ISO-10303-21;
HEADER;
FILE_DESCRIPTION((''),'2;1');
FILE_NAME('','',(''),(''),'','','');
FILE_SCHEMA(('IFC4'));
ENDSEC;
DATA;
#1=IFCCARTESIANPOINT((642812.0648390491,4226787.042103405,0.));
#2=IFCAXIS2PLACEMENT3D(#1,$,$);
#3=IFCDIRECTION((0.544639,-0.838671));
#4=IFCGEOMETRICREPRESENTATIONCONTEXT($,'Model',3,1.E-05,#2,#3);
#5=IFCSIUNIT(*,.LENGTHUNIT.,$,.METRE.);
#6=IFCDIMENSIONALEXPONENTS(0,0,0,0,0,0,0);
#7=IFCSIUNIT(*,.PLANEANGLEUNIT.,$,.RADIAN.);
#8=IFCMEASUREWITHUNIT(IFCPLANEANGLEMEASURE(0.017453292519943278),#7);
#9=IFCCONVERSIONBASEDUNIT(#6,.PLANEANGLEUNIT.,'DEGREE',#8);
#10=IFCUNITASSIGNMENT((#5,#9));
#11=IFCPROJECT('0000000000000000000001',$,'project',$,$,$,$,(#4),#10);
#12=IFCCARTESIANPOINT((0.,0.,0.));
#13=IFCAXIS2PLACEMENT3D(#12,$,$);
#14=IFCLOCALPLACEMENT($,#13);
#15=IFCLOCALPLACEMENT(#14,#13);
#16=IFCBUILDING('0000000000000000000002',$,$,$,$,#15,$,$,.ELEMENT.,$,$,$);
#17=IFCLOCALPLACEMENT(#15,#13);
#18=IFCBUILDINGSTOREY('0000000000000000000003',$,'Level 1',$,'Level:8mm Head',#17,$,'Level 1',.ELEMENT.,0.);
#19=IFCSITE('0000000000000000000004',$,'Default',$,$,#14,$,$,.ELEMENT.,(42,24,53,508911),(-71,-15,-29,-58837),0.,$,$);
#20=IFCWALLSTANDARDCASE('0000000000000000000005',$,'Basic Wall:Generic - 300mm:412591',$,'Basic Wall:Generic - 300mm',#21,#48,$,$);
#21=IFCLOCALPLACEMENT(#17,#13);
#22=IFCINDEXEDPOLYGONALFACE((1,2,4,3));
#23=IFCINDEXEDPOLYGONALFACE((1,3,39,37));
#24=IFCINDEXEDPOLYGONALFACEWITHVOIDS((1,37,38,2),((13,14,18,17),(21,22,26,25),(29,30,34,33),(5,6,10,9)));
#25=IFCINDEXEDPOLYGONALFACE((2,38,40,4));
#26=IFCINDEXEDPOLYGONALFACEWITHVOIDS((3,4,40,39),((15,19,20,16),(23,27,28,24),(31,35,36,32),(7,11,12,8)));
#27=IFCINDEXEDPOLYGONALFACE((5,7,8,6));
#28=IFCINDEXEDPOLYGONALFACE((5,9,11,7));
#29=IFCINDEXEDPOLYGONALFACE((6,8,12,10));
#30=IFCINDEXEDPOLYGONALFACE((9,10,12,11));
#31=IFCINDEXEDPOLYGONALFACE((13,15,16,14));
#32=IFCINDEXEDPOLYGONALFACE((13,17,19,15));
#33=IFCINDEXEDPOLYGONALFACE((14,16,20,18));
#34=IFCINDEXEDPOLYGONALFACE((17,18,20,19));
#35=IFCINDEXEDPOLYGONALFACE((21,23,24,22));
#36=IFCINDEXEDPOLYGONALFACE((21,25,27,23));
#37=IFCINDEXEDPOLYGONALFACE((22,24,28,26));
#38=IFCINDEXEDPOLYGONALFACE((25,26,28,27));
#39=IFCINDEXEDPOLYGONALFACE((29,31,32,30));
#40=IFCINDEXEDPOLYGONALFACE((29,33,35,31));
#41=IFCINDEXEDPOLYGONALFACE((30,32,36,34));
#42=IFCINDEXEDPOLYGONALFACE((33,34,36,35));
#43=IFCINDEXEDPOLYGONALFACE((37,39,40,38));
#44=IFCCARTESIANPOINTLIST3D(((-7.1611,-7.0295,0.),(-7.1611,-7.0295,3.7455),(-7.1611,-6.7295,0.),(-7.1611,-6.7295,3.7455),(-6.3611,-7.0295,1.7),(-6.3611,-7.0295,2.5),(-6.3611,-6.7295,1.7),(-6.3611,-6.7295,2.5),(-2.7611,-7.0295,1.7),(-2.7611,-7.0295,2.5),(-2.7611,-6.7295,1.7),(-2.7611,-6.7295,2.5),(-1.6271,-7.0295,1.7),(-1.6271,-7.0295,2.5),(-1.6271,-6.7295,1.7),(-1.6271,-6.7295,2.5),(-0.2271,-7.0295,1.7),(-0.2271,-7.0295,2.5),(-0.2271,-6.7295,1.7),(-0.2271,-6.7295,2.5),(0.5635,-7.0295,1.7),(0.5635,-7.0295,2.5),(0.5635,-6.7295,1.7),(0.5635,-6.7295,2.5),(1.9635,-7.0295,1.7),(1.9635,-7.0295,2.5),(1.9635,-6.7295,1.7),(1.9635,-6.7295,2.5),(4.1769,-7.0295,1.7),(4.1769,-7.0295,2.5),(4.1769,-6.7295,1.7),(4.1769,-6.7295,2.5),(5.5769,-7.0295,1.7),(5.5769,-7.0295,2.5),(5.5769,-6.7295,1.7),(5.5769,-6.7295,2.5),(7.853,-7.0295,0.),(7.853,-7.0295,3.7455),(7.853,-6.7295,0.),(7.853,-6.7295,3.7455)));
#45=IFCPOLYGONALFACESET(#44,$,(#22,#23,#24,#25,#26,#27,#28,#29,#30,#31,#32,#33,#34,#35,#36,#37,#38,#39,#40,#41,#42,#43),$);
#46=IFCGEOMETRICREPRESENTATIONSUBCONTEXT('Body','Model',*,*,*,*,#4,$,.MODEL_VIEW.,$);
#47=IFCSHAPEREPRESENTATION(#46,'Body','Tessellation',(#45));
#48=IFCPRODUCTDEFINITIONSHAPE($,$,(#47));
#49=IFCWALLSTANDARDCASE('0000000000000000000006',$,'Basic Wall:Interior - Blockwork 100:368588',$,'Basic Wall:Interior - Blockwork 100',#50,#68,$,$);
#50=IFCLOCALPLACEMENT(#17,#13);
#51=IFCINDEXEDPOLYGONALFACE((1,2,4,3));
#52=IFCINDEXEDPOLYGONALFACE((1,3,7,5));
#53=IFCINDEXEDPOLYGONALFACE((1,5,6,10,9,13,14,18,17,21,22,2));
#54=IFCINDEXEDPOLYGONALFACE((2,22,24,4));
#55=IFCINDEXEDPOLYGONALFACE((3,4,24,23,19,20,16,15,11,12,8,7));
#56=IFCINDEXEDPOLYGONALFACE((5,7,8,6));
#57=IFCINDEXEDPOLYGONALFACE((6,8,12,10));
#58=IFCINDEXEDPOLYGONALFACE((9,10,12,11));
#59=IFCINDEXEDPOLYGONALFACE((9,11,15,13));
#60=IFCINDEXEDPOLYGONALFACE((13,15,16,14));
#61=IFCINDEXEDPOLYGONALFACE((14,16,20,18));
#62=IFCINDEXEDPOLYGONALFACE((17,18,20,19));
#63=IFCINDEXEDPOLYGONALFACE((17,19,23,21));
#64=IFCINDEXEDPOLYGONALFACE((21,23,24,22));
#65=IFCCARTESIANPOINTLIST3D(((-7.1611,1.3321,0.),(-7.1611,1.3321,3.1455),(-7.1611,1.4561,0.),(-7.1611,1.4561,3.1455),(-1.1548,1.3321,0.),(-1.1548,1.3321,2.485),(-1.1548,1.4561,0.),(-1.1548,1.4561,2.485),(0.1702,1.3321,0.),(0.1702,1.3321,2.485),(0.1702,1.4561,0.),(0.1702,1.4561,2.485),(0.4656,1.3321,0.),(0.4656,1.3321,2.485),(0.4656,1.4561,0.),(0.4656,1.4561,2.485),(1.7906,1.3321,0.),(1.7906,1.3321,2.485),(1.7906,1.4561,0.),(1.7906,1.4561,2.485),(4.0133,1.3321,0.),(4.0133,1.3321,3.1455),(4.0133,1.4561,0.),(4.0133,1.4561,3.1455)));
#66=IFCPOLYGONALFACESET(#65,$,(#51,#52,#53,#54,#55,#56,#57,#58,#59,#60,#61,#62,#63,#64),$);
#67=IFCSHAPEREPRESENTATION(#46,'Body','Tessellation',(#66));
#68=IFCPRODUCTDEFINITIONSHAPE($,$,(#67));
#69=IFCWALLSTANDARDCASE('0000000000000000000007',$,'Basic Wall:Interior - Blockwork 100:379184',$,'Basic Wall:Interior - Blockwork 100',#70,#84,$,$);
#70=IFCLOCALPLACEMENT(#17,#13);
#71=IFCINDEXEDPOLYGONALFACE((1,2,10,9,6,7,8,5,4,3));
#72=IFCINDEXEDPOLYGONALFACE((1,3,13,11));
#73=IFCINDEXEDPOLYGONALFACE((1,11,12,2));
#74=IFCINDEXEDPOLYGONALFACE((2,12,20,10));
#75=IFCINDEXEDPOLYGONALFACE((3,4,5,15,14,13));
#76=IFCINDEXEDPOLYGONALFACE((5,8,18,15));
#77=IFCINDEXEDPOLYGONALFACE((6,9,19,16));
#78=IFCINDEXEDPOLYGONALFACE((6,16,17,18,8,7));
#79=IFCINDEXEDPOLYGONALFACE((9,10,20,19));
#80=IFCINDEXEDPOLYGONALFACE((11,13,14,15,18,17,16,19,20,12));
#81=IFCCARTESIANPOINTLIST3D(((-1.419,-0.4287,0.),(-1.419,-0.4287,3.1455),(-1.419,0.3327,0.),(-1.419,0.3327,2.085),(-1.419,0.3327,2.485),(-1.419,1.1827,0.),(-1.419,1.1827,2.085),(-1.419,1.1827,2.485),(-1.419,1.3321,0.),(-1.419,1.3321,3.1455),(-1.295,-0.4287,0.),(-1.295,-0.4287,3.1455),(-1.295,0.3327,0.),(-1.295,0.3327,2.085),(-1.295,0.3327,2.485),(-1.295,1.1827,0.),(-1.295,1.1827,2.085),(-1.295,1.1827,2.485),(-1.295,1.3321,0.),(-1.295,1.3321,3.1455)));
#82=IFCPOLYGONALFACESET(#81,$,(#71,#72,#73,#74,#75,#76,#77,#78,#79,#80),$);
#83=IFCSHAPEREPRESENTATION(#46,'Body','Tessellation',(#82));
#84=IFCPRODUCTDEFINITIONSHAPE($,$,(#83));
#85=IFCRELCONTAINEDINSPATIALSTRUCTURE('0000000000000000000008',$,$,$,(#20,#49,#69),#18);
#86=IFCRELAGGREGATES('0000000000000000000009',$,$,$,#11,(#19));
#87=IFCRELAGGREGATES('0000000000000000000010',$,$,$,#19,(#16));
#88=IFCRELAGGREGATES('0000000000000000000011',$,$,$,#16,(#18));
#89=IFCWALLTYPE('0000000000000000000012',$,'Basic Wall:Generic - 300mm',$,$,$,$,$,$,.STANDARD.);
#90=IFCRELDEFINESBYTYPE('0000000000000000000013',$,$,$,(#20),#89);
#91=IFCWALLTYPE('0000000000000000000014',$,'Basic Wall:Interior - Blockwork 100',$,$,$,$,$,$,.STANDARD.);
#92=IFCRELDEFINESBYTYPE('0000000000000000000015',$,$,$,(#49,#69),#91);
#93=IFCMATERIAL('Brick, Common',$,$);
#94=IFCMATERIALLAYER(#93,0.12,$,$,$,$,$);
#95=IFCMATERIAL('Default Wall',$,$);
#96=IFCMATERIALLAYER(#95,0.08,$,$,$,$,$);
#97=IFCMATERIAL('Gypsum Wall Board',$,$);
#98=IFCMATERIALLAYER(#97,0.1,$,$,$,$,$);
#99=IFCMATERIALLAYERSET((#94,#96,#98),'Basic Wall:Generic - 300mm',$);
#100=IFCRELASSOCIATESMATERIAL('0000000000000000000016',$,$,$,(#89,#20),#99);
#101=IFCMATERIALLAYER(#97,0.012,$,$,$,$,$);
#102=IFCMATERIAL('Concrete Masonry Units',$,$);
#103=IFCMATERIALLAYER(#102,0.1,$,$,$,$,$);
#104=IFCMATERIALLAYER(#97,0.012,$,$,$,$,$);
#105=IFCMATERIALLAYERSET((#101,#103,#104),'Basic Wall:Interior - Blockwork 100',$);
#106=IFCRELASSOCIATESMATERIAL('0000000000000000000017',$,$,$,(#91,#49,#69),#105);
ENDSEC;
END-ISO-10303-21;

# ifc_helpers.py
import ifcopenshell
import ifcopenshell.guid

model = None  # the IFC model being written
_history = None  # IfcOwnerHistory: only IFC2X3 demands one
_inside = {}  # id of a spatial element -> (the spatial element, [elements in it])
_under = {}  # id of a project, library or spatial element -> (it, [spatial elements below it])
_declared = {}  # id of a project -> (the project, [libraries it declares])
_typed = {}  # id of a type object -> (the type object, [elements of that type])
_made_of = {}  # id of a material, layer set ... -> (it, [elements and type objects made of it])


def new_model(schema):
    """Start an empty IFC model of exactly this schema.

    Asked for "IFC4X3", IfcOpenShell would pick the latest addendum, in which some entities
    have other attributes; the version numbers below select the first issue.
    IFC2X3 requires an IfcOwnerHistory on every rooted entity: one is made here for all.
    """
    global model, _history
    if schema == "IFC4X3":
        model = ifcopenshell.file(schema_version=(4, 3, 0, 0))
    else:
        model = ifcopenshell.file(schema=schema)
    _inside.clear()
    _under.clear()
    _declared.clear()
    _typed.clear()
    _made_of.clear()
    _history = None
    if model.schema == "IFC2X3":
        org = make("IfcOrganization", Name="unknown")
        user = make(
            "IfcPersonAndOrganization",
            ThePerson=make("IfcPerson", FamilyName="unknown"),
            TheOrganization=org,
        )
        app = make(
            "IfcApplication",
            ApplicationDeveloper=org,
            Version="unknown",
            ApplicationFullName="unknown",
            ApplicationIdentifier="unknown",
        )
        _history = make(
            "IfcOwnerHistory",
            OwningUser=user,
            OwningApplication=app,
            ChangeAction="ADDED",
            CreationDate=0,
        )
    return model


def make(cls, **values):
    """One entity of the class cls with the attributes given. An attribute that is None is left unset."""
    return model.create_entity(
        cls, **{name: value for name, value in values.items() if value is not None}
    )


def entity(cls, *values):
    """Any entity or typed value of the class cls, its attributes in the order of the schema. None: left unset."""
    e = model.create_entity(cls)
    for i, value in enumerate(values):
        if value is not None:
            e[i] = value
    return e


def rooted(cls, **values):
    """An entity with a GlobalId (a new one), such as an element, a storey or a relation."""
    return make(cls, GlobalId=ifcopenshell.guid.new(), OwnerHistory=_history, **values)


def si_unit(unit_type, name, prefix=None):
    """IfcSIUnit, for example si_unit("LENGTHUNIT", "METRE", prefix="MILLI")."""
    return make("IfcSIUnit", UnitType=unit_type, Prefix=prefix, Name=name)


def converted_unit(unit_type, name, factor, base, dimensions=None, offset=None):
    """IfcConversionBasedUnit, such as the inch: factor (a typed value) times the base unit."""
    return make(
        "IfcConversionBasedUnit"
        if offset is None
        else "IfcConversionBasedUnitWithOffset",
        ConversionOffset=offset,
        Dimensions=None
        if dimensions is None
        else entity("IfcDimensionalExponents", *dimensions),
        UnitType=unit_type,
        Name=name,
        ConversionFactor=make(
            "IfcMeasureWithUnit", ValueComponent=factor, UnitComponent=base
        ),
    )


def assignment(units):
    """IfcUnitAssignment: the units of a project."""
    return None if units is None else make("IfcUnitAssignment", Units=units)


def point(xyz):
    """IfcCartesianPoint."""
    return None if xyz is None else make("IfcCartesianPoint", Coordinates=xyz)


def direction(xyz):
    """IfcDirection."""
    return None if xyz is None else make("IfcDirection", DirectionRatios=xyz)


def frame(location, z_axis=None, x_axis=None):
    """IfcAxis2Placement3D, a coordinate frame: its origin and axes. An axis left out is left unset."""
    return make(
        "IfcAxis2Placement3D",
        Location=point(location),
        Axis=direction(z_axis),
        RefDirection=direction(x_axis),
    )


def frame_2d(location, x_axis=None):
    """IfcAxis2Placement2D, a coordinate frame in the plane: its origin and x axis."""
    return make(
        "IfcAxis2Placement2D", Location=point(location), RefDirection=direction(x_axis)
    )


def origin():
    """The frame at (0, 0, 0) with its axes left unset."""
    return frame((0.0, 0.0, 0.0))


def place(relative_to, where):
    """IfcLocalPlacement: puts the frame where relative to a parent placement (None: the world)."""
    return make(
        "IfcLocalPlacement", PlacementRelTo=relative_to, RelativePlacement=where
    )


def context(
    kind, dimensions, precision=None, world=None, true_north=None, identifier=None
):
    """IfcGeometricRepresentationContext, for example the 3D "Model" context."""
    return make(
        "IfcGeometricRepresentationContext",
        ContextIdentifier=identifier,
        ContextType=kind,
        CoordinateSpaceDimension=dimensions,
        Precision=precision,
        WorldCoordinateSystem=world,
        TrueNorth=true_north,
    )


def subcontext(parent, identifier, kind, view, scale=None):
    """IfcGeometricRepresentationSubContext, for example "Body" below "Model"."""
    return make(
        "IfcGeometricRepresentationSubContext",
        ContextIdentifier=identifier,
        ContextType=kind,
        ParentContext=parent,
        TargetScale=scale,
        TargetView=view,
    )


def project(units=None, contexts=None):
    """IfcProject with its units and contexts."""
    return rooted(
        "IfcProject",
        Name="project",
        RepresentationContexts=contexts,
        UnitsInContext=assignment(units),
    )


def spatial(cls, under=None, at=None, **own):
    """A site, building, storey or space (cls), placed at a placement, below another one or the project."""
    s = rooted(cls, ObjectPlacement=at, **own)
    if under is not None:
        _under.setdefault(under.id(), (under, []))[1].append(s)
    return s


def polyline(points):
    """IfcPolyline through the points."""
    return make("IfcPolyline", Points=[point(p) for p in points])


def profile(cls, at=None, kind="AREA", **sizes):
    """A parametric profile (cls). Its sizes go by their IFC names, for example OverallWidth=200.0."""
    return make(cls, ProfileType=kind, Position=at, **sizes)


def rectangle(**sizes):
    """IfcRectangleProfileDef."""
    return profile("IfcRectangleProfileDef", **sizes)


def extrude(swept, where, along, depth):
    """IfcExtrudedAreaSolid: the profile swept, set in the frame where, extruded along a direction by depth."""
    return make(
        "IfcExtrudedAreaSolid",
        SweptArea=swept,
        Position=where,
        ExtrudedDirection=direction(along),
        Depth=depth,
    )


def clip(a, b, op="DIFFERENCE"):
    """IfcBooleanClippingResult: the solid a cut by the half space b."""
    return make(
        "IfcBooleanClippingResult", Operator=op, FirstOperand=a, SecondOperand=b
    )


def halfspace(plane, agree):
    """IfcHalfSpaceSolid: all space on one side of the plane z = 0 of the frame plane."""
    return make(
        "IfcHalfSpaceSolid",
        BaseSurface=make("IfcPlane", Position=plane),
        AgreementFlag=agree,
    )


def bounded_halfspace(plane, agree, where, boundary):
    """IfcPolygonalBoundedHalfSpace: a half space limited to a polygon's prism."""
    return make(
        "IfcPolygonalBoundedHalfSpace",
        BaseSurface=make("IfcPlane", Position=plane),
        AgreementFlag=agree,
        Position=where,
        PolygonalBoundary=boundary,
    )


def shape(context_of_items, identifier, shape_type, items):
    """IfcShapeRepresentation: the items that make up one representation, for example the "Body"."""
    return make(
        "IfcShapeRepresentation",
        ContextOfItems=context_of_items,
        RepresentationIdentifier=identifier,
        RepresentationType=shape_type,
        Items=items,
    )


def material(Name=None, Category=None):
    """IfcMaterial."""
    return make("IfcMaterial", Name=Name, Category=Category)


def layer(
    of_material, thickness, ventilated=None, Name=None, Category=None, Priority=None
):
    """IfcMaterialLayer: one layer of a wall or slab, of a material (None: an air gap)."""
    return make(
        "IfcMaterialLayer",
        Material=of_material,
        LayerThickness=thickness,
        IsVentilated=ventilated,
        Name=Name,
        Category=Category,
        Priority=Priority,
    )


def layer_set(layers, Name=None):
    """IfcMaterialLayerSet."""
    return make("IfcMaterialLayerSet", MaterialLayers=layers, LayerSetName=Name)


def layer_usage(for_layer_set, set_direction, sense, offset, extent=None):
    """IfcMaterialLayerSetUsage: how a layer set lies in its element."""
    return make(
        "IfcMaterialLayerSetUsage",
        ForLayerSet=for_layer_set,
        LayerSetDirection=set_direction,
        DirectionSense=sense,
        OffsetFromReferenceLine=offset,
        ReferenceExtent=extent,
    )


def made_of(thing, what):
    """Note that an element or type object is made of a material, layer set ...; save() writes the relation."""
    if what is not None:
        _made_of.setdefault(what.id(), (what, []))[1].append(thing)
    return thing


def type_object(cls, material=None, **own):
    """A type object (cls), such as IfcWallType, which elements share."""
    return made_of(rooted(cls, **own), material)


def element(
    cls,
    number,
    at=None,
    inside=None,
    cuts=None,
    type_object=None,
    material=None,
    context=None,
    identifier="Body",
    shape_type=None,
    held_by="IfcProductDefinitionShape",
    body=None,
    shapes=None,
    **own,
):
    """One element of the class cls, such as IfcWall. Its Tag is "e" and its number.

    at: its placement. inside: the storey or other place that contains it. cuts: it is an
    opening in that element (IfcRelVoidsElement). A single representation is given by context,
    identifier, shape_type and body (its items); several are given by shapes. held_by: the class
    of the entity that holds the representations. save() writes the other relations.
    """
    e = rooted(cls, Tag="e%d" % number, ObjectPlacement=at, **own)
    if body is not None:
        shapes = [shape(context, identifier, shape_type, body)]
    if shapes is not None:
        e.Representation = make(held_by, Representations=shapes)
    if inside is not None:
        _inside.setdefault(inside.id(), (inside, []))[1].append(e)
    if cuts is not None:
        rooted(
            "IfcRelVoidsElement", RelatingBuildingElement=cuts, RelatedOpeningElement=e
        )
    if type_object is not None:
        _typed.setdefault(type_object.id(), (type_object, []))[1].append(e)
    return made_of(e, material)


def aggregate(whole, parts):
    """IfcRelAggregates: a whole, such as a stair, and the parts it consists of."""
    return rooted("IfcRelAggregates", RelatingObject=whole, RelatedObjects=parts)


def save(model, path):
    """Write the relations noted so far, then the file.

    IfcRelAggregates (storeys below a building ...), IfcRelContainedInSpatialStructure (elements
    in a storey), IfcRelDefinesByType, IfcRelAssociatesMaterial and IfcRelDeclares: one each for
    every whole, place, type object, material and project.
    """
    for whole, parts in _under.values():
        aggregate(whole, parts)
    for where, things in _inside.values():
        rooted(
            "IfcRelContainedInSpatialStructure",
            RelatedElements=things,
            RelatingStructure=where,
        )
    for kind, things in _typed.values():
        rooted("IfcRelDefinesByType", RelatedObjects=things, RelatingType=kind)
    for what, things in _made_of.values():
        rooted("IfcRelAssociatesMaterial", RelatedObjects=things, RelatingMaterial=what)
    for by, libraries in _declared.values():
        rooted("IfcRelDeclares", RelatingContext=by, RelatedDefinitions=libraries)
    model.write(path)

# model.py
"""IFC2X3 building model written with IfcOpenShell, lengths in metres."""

from ifc_helpers import new_model, entity, si_unit, converted_unit, direction, frame, frame_2d, origin, place, context, subcontext, project, spatial, polyline, rectangle, extrude, clip, halfspace, bounded_halfspace, material, layer, layer_set, layer_usage, type_object, element, save


model = new_model("IFC2X3")

# Units and contexts
model_context = context("Model", 3, precision=1e-05, world=frame((642812.0648390491, 4226787.042103405, 0.0)), true_north=direction((0.544639, -0.838671)))
body_context = subcontext(model_context, "Body", "Model", "MODEL_VIEW")
ifc_project = project(units=[si_unit("LENGTHUNIT", "METRE"), converted_unit("PLANEANGLEUNIT", "DEGREE", entity("IfcPlaneAngleMeasure", 0.017453292519943278), si_unit("PLANEANGLEUNIT", "RADIAN"), dimensions=[0, 0, 0, 0, 0, 0, 0])], contexts=[model_context])

# Site, building, storey
site_placement = place(None, origin())
site = spatial("IfcSite", under=ifc_project, at=site_placement, Name="Default", CompositionType="ELEMENT", RefLatitude=(42, 24, 53, 508911), RefLongitude=(-71, -15, -29, -58837), RefElevation=0.0)
building_placement = place(site_placement, origin())
building = spatial("IfcBuilding", under=site, at=building_placement, CompositionType="ELEMENT")
storey_placement = place(building_placement, origin())
storey = spatial("IfcBuildingStorey", under=building, at=storey_placement, Name="Level 1", ObjectType="Level:8mm Head", LongName="Level 1", CompositionType="ELEMENT", Elevation=0.0)

# Shared definitions
ifc_material_1 = material(Name="Gypsum Wall Board")

# Shared definitions
ifc_material_2 = material(Name="Brick, Common")
ifc_layer_1 = layer(ifc_material_2, 0.12)
ifc_material_3 = material(Name="Default Wall")
ifc_layer_2 = layer(ifc_material_3, 0.08)
ifc_layer_3 = layer(ifc_material_1, 0.1)
ifc_layer_set_1 = layer_set([ifc_layer_1, ifc_layer_2, ifc_layer_3], Name="Basic Wall:Generic - 300mm")
ifc_layer_usage_1 = layer_usage(ifc_layer_set_1, "AXIS2", "POSITIVE", -0.15)
wall_type_1 = type_object("IfcWallType", Name="Basic Wall:Generic - 300mm", PredefinedType="STANDARD", material=ifc_layer_set_1)

# Walls, openings
wall_1_placement = place(storey_placement, frame((-7.1611, -6.8795, 0.0)))
wall_1 = element("IfcWallStandardCase", 1, at=wall_1_placement, inside=storey, type_object=wall_type_1, material=ifc_layer_usage_1, Name="Basic Wall:Generic - 300mm:412591", ObjectType="Basic Wall:Generic - 300mm", context=body_context, shape_type="Clipping", body=[
    clip(extrude(rectangle(XDim=15.014, YDim=0.3, at=frame_2d((7.507, 0.0), x_axis=(-1.0, 0.0))), origin(), (0.0, 0.0, 1.0), 3.7455), halfspace(origin(), True)),
])
opening_1_placement = place(wall_1_placement, frame((4.4, 0.15, 1.7)))
element("IfcOpeningElement", 2, at=opening_1_placement, cuts=wall_1, ObjectType="Opening", context=body_context, shape_type="SweptSolid", body=[
    extrude(rectangle(XDim=0.8, YDim=3.6, at=frame_2d((0.4, 1.8), x_axis=(-1.0, 0.0))), frame((0.0, 0.0, 0.0), z_axis=(0.0, -1.0, 0.0), x_axis=(0.0, 0.0, 1.0)), (0.0, 0.0, 1.0), 0.3),
])
opening_2_placement = place(wall_1_placement, frame((6.934, 0.15, 1.7)))
element("IfcOpeningElement", 3, at=opening_2_placement, cuts=wall_1, ObjectType="Opening", context=body_context, shape_type="SweptSolid", body=[
    extrude(rectangle(XDim=0.8, YDim=1.4, at=frame_2d((0.4, 0.7), x_axis=(-1.0, 0.0))), frame((0.0, 0.0, 0.0), z_axis=(0.0, -1.0, 0.0), x_axis=(0.0, 0.0, 1.0)), (0.0, 0.0, 1.0), 0.3),
])
opening_3_placement = place(wall_1_placement, frame((9.1246, 0.15, 1.7)))
element("IfcOpeningElement", 4, at=opening_3_placement, cuts=wall_1, ObjectType="Opening", context=body_context, shape_type="SweptSolid", body=[
    extrude(rectangle(XDim=0.8, YDim=1.4, at=frame_2d((0.4, 0.7), x_axis=(-1.0, 0.0))), frame((0.0, 0.0, 0.0), z_axis=(0.0, -1.0, 0.0), x_axis=(0.0, 0.0, 1.0)), (0.0, 0.0, 1.0), 0.3),
])
opening_4_placement = place(wall_1_placement, frame((12.738, 0.15, 1.7)))
element("IfcOpeningElement", 5, at=opening_4_placement, cuts=wall_1, ObjectType="Opening", context=body_context, shape_type="SweptSolid", body=[
    extrude(rectangle(XDim=0.8, YDim=1.4, at=frame_2d((0.4, 0.7), x_axis=(-1.0, 0.0))), frame((0.0, 0.0, 0.0), z_axis=(0.0, -1.0, 0.0), x_axis=(0.0, 0.0, 1.0)), (0.0, 0.0, 1.0), 0.3),
])
ifc_layer_4 = layer(ifc_material_1, 0.012)
ifc_material_4 = material(Name="Concrete Masonry Units")
ifc_layer_5 = layer(ifc_material_4, 0.1)
ifc_layer_6 = layer(ifc_material_1, 0.012)
ifc_layer_set_2 = layer_set([ifc_layer_4, ifc_layer_5, ifc_layer_6], Name="Basic Wall:Interior - Blockwork 100")
ifc_layer_usage_2 = layer_usage(ifc_layer_set_2, "AXIS2", "NEGATIVE", 0.062)
wall_type_2 = type_object("IfcWallType", Name="Basic Wall:Interior - Blockwork 100", PredefinedType="STANDARD", material=ifc_layer_set_2)
wall_2_placement = place(storey_placement, frame((-7.1611, 1.3941, 0.0)))
wall_2 = element("IfcWallStandardCase", 6, at=wall_2_placement, inside=storey, type_object=wall_type_2, material=ifc_layer_usage_2, Name="Basic Wall:Interior - Blockwork 100:368588", ObjectType="Basic Wall:Interior - Blockwork 100", context=body_context, shape_type="Clipping", body=[
    clip(extrude(rectangle(XDim=11.1744, YDim=0.124, at=frame_2d((5.5872, 0.0), x_axis=(1.0, 0.0))), origin(), (0.0, 0.0, 1.0), 3.1455), bounded_halfspace(frame((0.0, -0.062, 3.1455), z_axis=(0.0, 0.0, -1.0), x_axis=(1.0, 0.0, 0.0)), True, frame((0.0, -0.062, 3.1455)), polyline([(0.0, 0.0), (5.742, 0.0), (5.866, 0.0), (11.1744, 0.0), (11.1744, 0.124), (11.0494, 0.124), (9.7278, 0.124), (9.3028, 0.124), (7.5415, 0.124), (7.4165, 0.124), (5.1501, 0.124), (4.7251, 0.124), (0.5774, 0.124), (0.1524, 0.124), (0.0, 0.124), (0.0, 0.0)]))),
])
opening_5_placement = place(wall_2_placement, frame((7.6266, -0.062, 0.0)))
element("IfcOpeningElement", 7, at=opening_5_placement, cuts=wall_2, ObjectType="Opening", context=body_context, shape_type="SweptSolid", body=[
    extrude(rectangle(XDim=2.485, YDim=1.325, at=frame_2d((1.2425, 0.6625), x_axis=(1.0, 0.0))), frame((0.0, 0.0, 0.0), z_axis=(0.0, 1.0, 0.0), x_axis=(0.0, 0.0, 1.0)), (0.0, 0.0, 1.0), 0.124),
])
opening_6_placement = place(wall_2_placement, frame((6.0063, -0.062, 0.0)))
element("IfcOpeningElement", 8, at=opening_6_placement, cuts=wall_2, ObjectType="Opening", context=body_context, shape_type="SweptSolid", body=[
    extrude(rectangle(XDim=2.485, YDim=1.325, at=frame_2d((1.2425, 0.6625), x_axis=(1.0, 0.0))), frame((0.0, 0.0, 0.0), z_axis=(0.0, 1.0, 0.0), x_axis=(0.0, 0.0, 1.0)), (0.0, 0.0, 1.0), 0.124),
])
wall_3_placement = place(storey_placement, frame((-1.357, 1.3321, 0.0), z_axis=(0.0, 0.0, 1.0), x_axis=(0.0, -1.0, 0.0)))
wall_3 = element("IfcWallStandardCase", 9, at=wall_3_placement, inside=storey, type_object=wall_type_2, material=ifc_layer_usage_2, Name="Basic Wall:Interior - Blockwork 100:379184", ObjectType="Basic Wall:Interior - Blockwork 100", context=body_context, shape_type="Clipping", body=[
    clip(extrude(rectangle(XDim=1.7607, YDim=0.124, at=frame_2d((0.8804, 0.0), x_axis=(1.0, 0.0))), origin(), (0.0, 0.0, 1.0), 3.1455), bounded_halfspace(frame((0.0, -0.062, 3.1455), z_axis=(0.0, 0.0, -1.0), x_axis=(0.0, 1.0, 0.0)), True, frame((0.0, -0.062, 3.1455)), polyline([(0.0, 0.0), (1.7607, 0.0), (1.7607, 0.124), (0.0, 0.124), (0.0, 0.0)]))),
])
opening_7_placement = place(wall_3_placement, frame((1.3321, 1.357, 0.0), z_axis=(0.0, 0.0, 1.0), x_axis=(0.0, 1.0, 0.0)))
element("IfcOpeningElement", 10, at=opening_7_placement, cuts=wall_3, ObjectType="Opening", context=body_context, shape_type="SweptSolid", body=[
    extrude(rectangle(XDim=2.085, YDim=0.85, at=frame_2d((0.0, 0.0), x_axis=(1.0, 0.0))), frame((-2.819, 0.7577, 1.0425), z_axis=(1.0, 0.0, 0.0), x_axis=(0.0, 0.0, 1.0)), (0.0, 0.0, 1.0), 3.048),
])
opening_8_placement = place(wall_3_placement, frame((1.3321, 1.357, 0.0), z_axis=(0.0, 0.0, 1.0), x_axis=(0.0, 1.0, 0.0)))
element("IfcOpeningElement", 11, at=opening_8_placement, cuts=wall_3, ObjectType="Opening", context=body_context, shape_type="SweptSolid", body=[
    extrude(rectangle(XDim=0.4, YDim=0.85, at=frame_2d((0.0, 0.0), x_axis=(0.0, 1.0))), frame((-2.819, 0.7577, 2.285), z_axis=(1.0, 0.0, 0.0), x_axis=(0.0, -1.0, 0.0)), (0.0, 0.0, 1.0), 3.048),
])

save(model, "model.ifc")
